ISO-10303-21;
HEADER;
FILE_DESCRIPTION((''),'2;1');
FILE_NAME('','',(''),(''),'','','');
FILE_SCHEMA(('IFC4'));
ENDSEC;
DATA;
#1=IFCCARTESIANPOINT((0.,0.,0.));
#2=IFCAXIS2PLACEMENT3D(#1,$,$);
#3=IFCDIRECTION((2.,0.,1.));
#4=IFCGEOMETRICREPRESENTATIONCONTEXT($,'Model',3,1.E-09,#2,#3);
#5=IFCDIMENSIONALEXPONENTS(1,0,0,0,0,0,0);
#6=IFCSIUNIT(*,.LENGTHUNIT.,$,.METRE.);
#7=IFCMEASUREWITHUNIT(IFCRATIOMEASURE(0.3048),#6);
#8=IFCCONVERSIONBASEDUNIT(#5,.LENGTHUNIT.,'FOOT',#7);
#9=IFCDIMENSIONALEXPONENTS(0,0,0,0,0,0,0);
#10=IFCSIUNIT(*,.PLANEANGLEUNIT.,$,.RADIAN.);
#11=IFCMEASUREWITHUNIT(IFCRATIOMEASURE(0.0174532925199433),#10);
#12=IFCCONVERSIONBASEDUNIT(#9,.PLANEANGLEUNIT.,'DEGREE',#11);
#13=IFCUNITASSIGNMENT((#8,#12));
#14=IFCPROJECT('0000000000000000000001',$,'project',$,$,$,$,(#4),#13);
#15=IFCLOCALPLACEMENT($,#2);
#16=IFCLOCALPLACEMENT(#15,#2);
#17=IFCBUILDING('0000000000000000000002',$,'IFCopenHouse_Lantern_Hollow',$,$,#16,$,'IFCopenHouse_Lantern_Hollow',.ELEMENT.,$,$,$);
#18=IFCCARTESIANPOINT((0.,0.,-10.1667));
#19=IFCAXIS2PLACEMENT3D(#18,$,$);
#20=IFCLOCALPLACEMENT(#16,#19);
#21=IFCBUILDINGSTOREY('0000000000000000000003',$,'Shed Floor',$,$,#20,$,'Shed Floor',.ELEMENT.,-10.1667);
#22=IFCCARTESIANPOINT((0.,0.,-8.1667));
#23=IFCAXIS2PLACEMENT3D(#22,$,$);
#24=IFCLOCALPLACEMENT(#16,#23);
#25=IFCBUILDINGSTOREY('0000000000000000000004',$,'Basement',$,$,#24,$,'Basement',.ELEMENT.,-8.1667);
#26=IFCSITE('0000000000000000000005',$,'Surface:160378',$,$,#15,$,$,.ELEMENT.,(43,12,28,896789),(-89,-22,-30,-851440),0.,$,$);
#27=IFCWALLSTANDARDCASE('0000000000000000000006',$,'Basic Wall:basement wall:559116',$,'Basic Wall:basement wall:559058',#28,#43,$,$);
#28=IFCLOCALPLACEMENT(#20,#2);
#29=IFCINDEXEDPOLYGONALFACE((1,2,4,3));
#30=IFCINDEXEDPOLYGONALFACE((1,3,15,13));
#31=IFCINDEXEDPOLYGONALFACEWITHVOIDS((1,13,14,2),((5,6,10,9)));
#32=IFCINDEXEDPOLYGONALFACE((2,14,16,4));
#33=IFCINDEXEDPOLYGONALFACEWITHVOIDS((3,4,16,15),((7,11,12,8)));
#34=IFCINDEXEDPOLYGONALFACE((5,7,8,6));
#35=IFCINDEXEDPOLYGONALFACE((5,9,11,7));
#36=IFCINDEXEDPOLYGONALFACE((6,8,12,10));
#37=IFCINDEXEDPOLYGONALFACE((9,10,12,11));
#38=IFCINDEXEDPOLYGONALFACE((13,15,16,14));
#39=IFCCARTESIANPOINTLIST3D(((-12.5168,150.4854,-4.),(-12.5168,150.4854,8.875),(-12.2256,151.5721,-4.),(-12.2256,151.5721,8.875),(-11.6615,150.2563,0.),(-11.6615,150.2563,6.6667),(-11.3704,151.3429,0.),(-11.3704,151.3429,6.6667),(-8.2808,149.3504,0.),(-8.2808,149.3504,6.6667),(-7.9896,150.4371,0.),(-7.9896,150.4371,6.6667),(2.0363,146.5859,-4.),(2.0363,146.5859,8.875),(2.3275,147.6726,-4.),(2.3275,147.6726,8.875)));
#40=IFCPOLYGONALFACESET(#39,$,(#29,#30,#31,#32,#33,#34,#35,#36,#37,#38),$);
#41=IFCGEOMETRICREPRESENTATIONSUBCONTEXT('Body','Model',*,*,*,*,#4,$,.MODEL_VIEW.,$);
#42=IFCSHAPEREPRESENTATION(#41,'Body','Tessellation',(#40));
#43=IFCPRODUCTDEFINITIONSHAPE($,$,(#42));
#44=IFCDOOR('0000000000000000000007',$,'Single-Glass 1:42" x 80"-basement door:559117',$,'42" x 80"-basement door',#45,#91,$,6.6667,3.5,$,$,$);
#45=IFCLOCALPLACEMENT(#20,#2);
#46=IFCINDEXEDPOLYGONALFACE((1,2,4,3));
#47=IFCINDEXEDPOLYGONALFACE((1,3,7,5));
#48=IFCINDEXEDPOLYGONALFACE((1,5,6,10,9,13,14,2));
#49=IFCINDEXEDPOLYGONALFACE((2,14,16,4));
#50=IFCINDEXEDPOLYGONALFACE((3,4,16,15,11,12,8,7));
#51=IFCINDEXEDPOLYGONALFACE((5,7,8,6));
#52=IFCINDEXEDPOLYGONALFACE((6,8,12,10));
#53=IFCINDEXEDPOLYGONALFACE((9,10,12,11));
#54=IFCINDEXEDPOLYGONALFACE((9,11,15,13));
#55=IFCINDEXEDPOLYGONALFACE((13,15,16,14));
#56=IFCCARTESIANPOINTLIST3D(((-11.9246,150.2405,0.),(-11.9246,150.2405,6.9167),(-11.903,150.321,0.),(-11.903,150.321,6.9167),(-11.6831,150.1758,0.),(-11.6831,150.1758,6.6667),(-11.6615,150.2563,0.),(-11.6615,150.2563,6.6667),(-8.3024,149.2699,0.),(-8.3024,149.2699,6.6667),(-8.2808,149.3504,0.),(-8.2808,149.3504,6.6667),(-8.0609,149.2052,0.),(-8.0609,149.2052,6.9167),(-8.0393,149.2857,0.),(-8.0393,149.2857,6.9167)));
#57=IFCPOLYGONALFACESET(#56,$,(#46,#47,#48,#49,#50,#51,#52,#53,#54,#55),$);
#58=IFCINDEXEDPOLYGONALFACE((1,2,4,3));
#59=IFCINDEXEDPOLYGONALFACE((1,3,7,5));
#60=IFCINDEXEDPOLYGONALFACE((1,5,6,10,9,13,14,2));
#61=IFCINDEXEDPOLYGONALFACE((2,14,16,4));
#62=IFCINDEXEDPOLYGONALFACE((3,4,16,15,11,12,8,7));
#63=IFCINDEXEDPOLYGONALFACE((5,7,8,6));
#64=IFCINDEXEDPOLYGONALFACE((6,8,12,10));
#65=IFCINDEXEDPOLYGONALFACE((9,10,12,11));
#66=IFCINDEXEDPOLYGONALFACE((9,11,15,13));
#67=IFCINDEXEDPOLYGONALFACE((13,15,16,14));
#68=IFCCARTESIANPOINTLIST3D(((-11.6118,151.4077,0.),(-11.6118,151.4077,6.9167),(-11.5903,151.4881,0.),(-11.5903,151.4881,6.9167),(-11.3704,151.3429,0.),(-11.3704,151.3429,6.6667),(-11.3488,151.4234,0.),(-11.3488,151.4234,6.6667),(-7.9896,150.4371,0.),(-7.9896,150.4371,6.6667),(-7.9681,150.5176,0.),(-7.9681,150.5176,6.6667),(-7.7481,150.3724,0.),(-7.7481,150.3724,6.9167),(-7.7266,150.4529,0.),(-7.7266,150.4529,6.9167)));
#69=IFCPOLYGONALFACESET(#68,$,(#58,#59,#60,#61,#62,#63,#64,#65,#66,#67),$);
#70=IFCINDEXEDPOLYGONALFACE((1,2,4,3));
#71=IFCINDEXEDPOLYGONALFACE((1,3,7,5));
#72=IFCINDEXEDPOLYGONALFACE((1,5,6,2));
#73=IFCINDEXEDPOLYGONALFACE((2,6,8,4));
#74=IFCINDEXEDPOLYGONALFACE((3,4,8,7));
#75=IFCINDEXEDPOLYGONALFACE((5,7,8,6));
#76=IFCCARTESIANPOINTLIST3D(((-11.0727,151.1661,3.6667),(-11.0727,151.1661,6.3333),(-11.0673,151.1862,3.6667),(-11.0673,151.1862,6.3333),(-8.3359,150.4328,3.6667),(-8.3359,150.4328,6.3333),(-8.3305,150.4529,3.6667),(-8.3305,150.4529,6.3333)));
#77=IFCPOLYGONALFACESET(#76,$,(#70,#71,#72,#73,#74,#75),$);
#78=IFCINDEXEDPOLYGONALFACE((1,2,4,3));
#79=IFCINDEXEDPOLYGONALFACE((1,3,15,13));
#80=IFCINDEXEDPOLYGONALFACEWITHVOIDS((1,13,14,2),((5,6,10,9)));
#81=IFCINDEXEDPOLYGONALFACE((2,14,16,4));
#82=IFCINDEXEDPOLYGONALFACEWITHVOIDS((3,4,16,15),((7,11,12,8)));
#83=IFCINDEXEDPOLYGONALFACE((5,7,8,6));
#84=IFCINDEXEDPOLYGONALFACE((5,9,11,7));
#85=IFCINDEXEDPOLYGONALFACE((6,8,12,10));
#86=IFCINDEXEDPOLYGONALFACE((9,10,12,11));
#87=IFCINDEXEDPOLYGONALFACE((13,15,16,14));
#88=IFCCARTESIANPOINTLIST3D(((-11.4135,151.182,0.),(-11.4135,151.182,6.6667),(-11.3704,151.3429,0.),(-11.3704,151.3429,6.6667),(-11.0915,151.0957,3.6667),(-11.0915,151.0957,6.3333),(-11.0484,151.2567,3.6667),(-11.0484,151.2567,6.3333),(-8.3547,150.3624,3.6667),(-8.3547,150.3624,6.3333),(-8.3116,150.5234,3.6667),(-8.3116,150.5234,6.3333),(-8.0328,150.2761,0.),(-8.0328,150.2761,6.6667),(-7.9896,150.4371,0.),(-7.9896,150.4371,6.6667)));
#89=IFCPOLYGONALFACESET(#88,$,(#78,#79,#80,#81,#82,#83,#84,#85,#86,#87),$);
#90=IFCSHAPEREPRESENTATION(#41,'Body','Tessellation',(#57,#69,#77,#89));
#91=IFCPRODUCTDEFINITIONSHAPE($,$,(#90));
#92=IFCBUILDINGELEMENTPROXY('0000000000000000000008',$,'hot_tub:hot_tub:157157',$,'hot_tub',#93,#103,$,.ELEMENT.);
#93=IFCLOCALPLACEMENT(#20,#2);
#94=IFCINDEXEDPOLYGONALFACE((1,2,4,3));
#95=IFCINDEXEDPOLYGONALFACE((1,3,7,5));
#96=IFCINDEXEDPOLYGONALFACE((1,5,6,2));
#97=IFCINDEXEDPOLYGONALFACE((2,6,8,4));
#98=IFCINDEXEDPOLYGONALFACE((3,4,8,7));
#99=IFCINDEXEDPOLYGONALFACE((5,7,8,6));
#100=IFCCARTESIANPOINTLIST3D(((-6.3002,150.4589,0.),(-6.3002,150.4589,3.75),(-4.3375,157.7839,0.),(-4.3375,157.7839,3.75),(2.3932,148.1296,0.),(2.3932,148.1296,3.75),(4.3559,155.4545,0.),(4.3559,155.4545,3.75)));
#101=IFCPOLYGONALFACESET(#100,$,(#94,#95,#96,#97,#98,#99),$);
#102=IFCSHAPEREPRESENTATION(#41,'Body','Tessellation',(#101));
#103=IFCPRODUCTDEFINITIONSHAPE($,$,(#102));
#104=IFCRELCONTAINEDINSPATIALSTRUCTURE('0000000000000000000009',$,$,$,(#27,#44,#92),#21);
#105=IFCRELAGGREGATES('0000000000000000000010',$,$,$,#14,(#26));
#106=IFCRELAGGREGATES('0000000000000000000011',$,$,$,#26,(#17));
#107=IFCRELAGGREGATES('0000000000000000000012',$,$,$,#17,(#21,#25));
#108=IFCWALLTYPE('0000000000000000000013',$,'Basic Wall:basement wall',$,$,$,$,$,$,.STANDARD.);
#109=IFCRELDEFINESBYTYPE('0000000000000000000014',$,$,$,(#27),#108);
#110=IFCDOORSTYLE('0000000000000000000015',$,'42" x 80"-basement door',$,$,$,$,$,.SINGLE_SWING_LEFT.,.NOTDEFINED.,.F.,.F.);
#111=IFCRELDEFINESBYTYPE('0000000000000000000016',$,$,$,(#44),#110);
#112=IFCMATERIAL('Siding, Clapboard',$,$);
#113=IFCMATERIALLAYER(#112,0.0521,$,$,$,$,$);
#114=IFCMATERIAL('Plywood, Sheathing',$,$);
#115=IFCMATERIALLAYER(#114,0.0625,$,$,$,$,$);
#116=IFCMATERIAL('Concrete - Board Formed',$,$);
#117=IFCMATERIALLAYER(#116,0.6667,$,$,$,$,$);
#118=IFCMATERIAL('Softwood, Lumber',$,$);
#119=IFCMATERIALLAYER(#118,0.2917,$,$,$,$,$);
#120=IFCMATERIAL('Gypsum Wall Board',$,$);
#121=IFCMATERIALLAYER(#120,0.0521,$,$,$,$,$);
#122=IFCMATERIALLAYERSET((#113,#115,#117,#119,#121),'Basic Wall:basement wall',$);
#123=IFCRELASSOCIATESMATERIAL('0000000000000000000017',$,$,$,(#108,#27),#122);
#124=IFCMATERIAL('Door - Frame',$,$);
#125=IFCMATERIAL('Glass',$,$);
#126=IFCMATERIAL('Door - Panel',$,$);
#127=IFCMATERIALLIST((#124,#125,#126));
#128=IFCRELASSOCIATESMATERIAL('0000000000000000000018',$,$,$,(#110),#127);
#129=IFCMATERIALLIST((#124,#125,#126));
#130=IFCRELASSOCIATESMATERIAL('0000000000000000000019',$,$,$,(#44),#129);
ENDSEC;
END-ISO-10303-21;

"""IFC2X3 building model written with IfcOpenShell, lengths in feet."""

from ifc_helpers import new_model, entity, si_unit, converted_unit, direction, frame, frame_2d, origin, origin_2d_with_axis, place, context, subcontext, project, spatial, polyline, rectangle, outline, extrude, source, transform, mapped, material, material_list, layer, layer_set, layer_usage, type_object, type_shapes, element, fill, save


model = new_model("IFC2X3")

# Units and contexts
model_context = context("Model", 3, precision=1e-09, world=origin(), true_north=direction((2.0, 0.0, 1.0)))
body_context = subcontext(model_context, "Body", "Model", "MODEL_VIEW")
ifc_project = project(units=[converted_unit("LENGTHUNIT", "FOOT", entity("IfcRatioMeasure", 0.3048), si_unit("LENGTHUNIT", "METRE"), dimensions=[1, 0, 0, 0, 0, 0, 0]), converted_unit("PLANEANGLEUNIT", "DEGREE", entity("IfcRatioMeasure", 0.0174532925199433), si_unit("PLANEANGLEUNIT", "RADIAN"), dimensions=[0, 0, 0, 0, 0, 0, 0])], contexts=[model_context])

# Site, building, storey
site_placement = place(None, origin())
site = spatial("IfcSite", under=ifc_project, at=site_placement, Name="Surface:160378", CompositionType="ELEMENT", RefLatitude=(43, 12, 28, 896789), RefLongitude=(-89, -22, -30, -851440), RefElevation=0.0)
building_placement = place(site_placement, origin())
building = spatial("IfcBuilding", under=site, at=building_placement, Name="IFCopenHouse_Lantern_Hollow", LongName="IFCopenHouse_Lantern_Hollow", CompositionType="ELEMENT")
storey_1_placement = place(building_placement, frame((0.0, 0.0, -10.1667)))
storey_1 = spatial("IfcBuildingStorey", under=building, at=storey_1_placement, Name="Shed Floor", LongName="Shed Floor", CompositionType="ELEMENT", Elevation=-10.1667)

# Shared definitions
ifc_material_1 = material(Name="Softwood, Lumber")
ifc_material_2 = material(Name="Gypsum Wall Board")

# Shared definitions
storey_2_placement = place(building_placement, frame((0.0, 0.0, -8.1667)))
storey_2 = spatial("IfcBuildingStorey", under=building, at=storey_2_placement, Name="Basement", LongName="Basement", CompositionType="ELEMENT", Elevation=-8.1667)

# Shared definitions
ifc_material_3 = material(Name="Glass")

# Shared definitions
ifc_material_4 = material(Name="Door - Frame")
ifc_material_5 = material(Name="Door - Panel")

# Shared definitions
ifc_material_6 = material(Name="Concrete - Board Formed")

# Shared definitions
ifc_material_7 = material(Name="Siding, Clapboard")
ifc_layer_1 = layer(ifc_material_7, 0.0521)
ifc_material_8 = material(Name="Plywood, Sheathing")
ifc_layer_2 = layer(ifc_material_8, 0.0625)
ifc_layer_3 = layer(ifc_material_6, 0.6667)
ifc_layer_4 = layer(ifc_material_1, 0.2917)
ifc_layer_5 = layer(ifc_material_2, 0.0521)
ifc_layer_set_1 = layer_set([ifc_layer_1, ifc_layer_2, ifc_layer_3, ifc_layer_4, ifc_layer_5], Name="Basic Wall:basement wall")
wall_type_1 = type_object("IfcWallType", Name="Basic Wall:basement wall", PredefinedType="STANDARD", material=ifc_layer_set_1)

# Wall, openings, door
ifc_layer_usage_1 = layer_usage(ifc_layer_set_1, "AXIS2", "NEGATIVE", 0.5625)
wall_1_placement = place(storey_1_placement, frame((-12.3712, 151.0288, -4.0), z_axis=(0.0, 0.0, 1.0), x_axis=(0.965926, -0.258819, 0.0)))
wall_1 = element("IfcWallStandardCase", 1, at=wall_1_placement, inside=storey_1, type_object=wall_type_1, material=ifc_layer_usage_1, Name="Basic Wall:basement wall:559116", ObjectType="Basic Wall:basement wall:559058", context=body_context, shape_type="SweptSolid", body=[
    extrude(rectangle(XDim=15.0665, YDim=1.125, at=frame_2d((7.5333, 0.0), x_axis=(-1.0, 0.0))), origin(), (0.0, 0.0, 1.0), 12.875),
])
opening_1_placement = place(wall_1_placement, frame((15.1419, -7.8646, 4.0)))
element("IfcOpeningElement", 2, at=opening_1_placement, cuts=wall_1, ObjectType="Opening", context=body_context, shape_type="SweptSolid", body=[
    extrude(rectangle(XDim=7.0, YDim=1.125, at=frame_2d((0.0, 0.0), x_axis=(0.0, 1.0))), frame((0.4871, 0.2812, 3.5), z_axis=(0.0, 1.0, 0.0), x_axis=(1.0, 0.0, 0.0)), (0.0, 0.0, 1.0), 7.0),
])
opening_2_placement = place(wall_1_placement, frame((0.8854, -0.5625, 4.0)))
opening_2 = element("IfcOpeningElement", 3, at=opening_2_placement, cuts=wall_1, ObjectType="Opening", context=body_context, shape_type="SweptSolid", body=[
    extrude(rectangle(XDim=3.5, YDim=6.6667, at=frame_2d((3.3333, 1.75), x_axis=(0.0, -1.0))), frame((0.0, 0.0, 0.0), z_axis=(0.0, 1.0, 0.0), x_axis=(0.0, 0.0, 1.0)), (0.0, 0.0, 1.0), 1.125),
])
ifc_material_list_1 = material_list([ifc_material_4, ifc_material_3, ifc_material_5])
ifc_material_list_2 = material_list([ifc_material_4, ifc_material_3, ifc_material_5])
door_style_1 = type_object("IfcDoorStyle", Name="42\" x 80\"-basement door", ConstructionType="NOTDEFINED", OperationType="SINGLE_SWING_LEFT", ParameterTakesPrecedence=False, Sizeable=False, material=ifc_material_list_2)
shared_shape_1 = source(origin(), body_context, "Body", "SweptSolid", [
    extrude(outline(polyline([(-1.75, -3.2708), (-1.75, 3.3958), (-2.0, 3.3958), (-2.0, -3.5208), (2.0, -3.5208), (2.0, 3.3958), (1.75, 3.3958), (1.75, -3.2708), (-1.75, -3.2708)])), frame((1.75, 0.0, 3.3958), z_axis=(0.0, 1.0, 0.0), x_axis=(1.0, 0.0, 0.0)), (0.0, 0.0, -1.0), 0.0833),
    extrude(outline(polyline([(-1.75, -3.2708), (-1.75, 3.3958), (-2.0, 3.3958), (-2.0, -3.5208), (2.0, -3.5208), (2.0, 3.3958), (1.75, 3.3958), (1.75, -3.2708), (-1.75, -3.2708)])), frame((1.75, 1.2083, 3.3958), z_axis=(0.0, 1.0, 0.0), x_axis=(1.0, 0.0, 0.0)), (0.0, 0.0, -1.0), 0.0833),
    extrude(rectangle(XDim=2.8333, YDim=0.0208, at=frame_2d((0.0, 0.0), x_axis=(1.0, 0.0))), frame((1.75, 1.0417, 3.6667)), (0.0, 0.0, 1.0), 2.6667),
    extrude(outline(polyline([(-3.3333, -1.75), (3.3333, -1.75), (3.3333, 1.75), (-3.3333, 1.75), (-3.3333, -1.75)]), holes=[polyline([(-3.0, 1.4167), (-0.3333, 1.4167), (-0.3333, -1.4167), (-3.0, -1.4167), (-3.0, 1.4167)])]), frame((1.75, 1.125, 3.3333), z_axis=(0.0, -1.0, 0.0), x_axis=(0.0, 0.0, -1.0)), (0.0, 0.0, 1.0), 0.1667),
])
type_shapes(door_style_1, [shared_shape_1])
door_1_placement = place(opening_2_placement, origin())
door_1 = element("IfcDoor", 4, at=door_1_placement, inside=storey_1, type_object=door_style_1, material=ifc_material_list_1, Name="Single-Glass 1:42\" x 80\"-basement door:559117", ObjectType="42\" x 80\"-basement door", OverallHeight=6.6667, OverallWidth=3.5, context=body_context, shape_type="MappedRepresentation", body=[
    mapped(shared_shape_1, transform((0.0, 0.0, 0.0), scale=1.0)),
])
fill(opening_2, door_1)

# Building element proxy
shared_shape_2 = source(origin(), body_context, "Body", "SweptSolid", [
    extrude(rectangle(XDim=7.5833, YDim=9.0, at=origin_2d_with_axis()), frame((4.5, 3.7917, 0.0), z_axis=(0.0, 0.0, 1.0), x_axis=(0.0, 1.0, 0.0)), (0.0, 0.0, 1.0), 3.75),
])
proxy_placement = place(storey_1_placement, frame((4.3559, 155.4545, 0.0), z_axis=(0.0, 0.0, 1.0), x_axis=(-0.965926, 0.258819, 0.0)))
element("IfcBuildingElementProxy", 5, at=proxy_placement, inside=storey_1, Name="hot_tub:hot_tub:157157", ObjectType="hot_tub", CompositionType="ELEMENT", context=body_context, shape_type="MappedRepresentation", body=[
    mapped(shared_shape_2, transform((0.0, 0.0, 0.0), scale=1.0)),
])

save(model, "model.ifc")
